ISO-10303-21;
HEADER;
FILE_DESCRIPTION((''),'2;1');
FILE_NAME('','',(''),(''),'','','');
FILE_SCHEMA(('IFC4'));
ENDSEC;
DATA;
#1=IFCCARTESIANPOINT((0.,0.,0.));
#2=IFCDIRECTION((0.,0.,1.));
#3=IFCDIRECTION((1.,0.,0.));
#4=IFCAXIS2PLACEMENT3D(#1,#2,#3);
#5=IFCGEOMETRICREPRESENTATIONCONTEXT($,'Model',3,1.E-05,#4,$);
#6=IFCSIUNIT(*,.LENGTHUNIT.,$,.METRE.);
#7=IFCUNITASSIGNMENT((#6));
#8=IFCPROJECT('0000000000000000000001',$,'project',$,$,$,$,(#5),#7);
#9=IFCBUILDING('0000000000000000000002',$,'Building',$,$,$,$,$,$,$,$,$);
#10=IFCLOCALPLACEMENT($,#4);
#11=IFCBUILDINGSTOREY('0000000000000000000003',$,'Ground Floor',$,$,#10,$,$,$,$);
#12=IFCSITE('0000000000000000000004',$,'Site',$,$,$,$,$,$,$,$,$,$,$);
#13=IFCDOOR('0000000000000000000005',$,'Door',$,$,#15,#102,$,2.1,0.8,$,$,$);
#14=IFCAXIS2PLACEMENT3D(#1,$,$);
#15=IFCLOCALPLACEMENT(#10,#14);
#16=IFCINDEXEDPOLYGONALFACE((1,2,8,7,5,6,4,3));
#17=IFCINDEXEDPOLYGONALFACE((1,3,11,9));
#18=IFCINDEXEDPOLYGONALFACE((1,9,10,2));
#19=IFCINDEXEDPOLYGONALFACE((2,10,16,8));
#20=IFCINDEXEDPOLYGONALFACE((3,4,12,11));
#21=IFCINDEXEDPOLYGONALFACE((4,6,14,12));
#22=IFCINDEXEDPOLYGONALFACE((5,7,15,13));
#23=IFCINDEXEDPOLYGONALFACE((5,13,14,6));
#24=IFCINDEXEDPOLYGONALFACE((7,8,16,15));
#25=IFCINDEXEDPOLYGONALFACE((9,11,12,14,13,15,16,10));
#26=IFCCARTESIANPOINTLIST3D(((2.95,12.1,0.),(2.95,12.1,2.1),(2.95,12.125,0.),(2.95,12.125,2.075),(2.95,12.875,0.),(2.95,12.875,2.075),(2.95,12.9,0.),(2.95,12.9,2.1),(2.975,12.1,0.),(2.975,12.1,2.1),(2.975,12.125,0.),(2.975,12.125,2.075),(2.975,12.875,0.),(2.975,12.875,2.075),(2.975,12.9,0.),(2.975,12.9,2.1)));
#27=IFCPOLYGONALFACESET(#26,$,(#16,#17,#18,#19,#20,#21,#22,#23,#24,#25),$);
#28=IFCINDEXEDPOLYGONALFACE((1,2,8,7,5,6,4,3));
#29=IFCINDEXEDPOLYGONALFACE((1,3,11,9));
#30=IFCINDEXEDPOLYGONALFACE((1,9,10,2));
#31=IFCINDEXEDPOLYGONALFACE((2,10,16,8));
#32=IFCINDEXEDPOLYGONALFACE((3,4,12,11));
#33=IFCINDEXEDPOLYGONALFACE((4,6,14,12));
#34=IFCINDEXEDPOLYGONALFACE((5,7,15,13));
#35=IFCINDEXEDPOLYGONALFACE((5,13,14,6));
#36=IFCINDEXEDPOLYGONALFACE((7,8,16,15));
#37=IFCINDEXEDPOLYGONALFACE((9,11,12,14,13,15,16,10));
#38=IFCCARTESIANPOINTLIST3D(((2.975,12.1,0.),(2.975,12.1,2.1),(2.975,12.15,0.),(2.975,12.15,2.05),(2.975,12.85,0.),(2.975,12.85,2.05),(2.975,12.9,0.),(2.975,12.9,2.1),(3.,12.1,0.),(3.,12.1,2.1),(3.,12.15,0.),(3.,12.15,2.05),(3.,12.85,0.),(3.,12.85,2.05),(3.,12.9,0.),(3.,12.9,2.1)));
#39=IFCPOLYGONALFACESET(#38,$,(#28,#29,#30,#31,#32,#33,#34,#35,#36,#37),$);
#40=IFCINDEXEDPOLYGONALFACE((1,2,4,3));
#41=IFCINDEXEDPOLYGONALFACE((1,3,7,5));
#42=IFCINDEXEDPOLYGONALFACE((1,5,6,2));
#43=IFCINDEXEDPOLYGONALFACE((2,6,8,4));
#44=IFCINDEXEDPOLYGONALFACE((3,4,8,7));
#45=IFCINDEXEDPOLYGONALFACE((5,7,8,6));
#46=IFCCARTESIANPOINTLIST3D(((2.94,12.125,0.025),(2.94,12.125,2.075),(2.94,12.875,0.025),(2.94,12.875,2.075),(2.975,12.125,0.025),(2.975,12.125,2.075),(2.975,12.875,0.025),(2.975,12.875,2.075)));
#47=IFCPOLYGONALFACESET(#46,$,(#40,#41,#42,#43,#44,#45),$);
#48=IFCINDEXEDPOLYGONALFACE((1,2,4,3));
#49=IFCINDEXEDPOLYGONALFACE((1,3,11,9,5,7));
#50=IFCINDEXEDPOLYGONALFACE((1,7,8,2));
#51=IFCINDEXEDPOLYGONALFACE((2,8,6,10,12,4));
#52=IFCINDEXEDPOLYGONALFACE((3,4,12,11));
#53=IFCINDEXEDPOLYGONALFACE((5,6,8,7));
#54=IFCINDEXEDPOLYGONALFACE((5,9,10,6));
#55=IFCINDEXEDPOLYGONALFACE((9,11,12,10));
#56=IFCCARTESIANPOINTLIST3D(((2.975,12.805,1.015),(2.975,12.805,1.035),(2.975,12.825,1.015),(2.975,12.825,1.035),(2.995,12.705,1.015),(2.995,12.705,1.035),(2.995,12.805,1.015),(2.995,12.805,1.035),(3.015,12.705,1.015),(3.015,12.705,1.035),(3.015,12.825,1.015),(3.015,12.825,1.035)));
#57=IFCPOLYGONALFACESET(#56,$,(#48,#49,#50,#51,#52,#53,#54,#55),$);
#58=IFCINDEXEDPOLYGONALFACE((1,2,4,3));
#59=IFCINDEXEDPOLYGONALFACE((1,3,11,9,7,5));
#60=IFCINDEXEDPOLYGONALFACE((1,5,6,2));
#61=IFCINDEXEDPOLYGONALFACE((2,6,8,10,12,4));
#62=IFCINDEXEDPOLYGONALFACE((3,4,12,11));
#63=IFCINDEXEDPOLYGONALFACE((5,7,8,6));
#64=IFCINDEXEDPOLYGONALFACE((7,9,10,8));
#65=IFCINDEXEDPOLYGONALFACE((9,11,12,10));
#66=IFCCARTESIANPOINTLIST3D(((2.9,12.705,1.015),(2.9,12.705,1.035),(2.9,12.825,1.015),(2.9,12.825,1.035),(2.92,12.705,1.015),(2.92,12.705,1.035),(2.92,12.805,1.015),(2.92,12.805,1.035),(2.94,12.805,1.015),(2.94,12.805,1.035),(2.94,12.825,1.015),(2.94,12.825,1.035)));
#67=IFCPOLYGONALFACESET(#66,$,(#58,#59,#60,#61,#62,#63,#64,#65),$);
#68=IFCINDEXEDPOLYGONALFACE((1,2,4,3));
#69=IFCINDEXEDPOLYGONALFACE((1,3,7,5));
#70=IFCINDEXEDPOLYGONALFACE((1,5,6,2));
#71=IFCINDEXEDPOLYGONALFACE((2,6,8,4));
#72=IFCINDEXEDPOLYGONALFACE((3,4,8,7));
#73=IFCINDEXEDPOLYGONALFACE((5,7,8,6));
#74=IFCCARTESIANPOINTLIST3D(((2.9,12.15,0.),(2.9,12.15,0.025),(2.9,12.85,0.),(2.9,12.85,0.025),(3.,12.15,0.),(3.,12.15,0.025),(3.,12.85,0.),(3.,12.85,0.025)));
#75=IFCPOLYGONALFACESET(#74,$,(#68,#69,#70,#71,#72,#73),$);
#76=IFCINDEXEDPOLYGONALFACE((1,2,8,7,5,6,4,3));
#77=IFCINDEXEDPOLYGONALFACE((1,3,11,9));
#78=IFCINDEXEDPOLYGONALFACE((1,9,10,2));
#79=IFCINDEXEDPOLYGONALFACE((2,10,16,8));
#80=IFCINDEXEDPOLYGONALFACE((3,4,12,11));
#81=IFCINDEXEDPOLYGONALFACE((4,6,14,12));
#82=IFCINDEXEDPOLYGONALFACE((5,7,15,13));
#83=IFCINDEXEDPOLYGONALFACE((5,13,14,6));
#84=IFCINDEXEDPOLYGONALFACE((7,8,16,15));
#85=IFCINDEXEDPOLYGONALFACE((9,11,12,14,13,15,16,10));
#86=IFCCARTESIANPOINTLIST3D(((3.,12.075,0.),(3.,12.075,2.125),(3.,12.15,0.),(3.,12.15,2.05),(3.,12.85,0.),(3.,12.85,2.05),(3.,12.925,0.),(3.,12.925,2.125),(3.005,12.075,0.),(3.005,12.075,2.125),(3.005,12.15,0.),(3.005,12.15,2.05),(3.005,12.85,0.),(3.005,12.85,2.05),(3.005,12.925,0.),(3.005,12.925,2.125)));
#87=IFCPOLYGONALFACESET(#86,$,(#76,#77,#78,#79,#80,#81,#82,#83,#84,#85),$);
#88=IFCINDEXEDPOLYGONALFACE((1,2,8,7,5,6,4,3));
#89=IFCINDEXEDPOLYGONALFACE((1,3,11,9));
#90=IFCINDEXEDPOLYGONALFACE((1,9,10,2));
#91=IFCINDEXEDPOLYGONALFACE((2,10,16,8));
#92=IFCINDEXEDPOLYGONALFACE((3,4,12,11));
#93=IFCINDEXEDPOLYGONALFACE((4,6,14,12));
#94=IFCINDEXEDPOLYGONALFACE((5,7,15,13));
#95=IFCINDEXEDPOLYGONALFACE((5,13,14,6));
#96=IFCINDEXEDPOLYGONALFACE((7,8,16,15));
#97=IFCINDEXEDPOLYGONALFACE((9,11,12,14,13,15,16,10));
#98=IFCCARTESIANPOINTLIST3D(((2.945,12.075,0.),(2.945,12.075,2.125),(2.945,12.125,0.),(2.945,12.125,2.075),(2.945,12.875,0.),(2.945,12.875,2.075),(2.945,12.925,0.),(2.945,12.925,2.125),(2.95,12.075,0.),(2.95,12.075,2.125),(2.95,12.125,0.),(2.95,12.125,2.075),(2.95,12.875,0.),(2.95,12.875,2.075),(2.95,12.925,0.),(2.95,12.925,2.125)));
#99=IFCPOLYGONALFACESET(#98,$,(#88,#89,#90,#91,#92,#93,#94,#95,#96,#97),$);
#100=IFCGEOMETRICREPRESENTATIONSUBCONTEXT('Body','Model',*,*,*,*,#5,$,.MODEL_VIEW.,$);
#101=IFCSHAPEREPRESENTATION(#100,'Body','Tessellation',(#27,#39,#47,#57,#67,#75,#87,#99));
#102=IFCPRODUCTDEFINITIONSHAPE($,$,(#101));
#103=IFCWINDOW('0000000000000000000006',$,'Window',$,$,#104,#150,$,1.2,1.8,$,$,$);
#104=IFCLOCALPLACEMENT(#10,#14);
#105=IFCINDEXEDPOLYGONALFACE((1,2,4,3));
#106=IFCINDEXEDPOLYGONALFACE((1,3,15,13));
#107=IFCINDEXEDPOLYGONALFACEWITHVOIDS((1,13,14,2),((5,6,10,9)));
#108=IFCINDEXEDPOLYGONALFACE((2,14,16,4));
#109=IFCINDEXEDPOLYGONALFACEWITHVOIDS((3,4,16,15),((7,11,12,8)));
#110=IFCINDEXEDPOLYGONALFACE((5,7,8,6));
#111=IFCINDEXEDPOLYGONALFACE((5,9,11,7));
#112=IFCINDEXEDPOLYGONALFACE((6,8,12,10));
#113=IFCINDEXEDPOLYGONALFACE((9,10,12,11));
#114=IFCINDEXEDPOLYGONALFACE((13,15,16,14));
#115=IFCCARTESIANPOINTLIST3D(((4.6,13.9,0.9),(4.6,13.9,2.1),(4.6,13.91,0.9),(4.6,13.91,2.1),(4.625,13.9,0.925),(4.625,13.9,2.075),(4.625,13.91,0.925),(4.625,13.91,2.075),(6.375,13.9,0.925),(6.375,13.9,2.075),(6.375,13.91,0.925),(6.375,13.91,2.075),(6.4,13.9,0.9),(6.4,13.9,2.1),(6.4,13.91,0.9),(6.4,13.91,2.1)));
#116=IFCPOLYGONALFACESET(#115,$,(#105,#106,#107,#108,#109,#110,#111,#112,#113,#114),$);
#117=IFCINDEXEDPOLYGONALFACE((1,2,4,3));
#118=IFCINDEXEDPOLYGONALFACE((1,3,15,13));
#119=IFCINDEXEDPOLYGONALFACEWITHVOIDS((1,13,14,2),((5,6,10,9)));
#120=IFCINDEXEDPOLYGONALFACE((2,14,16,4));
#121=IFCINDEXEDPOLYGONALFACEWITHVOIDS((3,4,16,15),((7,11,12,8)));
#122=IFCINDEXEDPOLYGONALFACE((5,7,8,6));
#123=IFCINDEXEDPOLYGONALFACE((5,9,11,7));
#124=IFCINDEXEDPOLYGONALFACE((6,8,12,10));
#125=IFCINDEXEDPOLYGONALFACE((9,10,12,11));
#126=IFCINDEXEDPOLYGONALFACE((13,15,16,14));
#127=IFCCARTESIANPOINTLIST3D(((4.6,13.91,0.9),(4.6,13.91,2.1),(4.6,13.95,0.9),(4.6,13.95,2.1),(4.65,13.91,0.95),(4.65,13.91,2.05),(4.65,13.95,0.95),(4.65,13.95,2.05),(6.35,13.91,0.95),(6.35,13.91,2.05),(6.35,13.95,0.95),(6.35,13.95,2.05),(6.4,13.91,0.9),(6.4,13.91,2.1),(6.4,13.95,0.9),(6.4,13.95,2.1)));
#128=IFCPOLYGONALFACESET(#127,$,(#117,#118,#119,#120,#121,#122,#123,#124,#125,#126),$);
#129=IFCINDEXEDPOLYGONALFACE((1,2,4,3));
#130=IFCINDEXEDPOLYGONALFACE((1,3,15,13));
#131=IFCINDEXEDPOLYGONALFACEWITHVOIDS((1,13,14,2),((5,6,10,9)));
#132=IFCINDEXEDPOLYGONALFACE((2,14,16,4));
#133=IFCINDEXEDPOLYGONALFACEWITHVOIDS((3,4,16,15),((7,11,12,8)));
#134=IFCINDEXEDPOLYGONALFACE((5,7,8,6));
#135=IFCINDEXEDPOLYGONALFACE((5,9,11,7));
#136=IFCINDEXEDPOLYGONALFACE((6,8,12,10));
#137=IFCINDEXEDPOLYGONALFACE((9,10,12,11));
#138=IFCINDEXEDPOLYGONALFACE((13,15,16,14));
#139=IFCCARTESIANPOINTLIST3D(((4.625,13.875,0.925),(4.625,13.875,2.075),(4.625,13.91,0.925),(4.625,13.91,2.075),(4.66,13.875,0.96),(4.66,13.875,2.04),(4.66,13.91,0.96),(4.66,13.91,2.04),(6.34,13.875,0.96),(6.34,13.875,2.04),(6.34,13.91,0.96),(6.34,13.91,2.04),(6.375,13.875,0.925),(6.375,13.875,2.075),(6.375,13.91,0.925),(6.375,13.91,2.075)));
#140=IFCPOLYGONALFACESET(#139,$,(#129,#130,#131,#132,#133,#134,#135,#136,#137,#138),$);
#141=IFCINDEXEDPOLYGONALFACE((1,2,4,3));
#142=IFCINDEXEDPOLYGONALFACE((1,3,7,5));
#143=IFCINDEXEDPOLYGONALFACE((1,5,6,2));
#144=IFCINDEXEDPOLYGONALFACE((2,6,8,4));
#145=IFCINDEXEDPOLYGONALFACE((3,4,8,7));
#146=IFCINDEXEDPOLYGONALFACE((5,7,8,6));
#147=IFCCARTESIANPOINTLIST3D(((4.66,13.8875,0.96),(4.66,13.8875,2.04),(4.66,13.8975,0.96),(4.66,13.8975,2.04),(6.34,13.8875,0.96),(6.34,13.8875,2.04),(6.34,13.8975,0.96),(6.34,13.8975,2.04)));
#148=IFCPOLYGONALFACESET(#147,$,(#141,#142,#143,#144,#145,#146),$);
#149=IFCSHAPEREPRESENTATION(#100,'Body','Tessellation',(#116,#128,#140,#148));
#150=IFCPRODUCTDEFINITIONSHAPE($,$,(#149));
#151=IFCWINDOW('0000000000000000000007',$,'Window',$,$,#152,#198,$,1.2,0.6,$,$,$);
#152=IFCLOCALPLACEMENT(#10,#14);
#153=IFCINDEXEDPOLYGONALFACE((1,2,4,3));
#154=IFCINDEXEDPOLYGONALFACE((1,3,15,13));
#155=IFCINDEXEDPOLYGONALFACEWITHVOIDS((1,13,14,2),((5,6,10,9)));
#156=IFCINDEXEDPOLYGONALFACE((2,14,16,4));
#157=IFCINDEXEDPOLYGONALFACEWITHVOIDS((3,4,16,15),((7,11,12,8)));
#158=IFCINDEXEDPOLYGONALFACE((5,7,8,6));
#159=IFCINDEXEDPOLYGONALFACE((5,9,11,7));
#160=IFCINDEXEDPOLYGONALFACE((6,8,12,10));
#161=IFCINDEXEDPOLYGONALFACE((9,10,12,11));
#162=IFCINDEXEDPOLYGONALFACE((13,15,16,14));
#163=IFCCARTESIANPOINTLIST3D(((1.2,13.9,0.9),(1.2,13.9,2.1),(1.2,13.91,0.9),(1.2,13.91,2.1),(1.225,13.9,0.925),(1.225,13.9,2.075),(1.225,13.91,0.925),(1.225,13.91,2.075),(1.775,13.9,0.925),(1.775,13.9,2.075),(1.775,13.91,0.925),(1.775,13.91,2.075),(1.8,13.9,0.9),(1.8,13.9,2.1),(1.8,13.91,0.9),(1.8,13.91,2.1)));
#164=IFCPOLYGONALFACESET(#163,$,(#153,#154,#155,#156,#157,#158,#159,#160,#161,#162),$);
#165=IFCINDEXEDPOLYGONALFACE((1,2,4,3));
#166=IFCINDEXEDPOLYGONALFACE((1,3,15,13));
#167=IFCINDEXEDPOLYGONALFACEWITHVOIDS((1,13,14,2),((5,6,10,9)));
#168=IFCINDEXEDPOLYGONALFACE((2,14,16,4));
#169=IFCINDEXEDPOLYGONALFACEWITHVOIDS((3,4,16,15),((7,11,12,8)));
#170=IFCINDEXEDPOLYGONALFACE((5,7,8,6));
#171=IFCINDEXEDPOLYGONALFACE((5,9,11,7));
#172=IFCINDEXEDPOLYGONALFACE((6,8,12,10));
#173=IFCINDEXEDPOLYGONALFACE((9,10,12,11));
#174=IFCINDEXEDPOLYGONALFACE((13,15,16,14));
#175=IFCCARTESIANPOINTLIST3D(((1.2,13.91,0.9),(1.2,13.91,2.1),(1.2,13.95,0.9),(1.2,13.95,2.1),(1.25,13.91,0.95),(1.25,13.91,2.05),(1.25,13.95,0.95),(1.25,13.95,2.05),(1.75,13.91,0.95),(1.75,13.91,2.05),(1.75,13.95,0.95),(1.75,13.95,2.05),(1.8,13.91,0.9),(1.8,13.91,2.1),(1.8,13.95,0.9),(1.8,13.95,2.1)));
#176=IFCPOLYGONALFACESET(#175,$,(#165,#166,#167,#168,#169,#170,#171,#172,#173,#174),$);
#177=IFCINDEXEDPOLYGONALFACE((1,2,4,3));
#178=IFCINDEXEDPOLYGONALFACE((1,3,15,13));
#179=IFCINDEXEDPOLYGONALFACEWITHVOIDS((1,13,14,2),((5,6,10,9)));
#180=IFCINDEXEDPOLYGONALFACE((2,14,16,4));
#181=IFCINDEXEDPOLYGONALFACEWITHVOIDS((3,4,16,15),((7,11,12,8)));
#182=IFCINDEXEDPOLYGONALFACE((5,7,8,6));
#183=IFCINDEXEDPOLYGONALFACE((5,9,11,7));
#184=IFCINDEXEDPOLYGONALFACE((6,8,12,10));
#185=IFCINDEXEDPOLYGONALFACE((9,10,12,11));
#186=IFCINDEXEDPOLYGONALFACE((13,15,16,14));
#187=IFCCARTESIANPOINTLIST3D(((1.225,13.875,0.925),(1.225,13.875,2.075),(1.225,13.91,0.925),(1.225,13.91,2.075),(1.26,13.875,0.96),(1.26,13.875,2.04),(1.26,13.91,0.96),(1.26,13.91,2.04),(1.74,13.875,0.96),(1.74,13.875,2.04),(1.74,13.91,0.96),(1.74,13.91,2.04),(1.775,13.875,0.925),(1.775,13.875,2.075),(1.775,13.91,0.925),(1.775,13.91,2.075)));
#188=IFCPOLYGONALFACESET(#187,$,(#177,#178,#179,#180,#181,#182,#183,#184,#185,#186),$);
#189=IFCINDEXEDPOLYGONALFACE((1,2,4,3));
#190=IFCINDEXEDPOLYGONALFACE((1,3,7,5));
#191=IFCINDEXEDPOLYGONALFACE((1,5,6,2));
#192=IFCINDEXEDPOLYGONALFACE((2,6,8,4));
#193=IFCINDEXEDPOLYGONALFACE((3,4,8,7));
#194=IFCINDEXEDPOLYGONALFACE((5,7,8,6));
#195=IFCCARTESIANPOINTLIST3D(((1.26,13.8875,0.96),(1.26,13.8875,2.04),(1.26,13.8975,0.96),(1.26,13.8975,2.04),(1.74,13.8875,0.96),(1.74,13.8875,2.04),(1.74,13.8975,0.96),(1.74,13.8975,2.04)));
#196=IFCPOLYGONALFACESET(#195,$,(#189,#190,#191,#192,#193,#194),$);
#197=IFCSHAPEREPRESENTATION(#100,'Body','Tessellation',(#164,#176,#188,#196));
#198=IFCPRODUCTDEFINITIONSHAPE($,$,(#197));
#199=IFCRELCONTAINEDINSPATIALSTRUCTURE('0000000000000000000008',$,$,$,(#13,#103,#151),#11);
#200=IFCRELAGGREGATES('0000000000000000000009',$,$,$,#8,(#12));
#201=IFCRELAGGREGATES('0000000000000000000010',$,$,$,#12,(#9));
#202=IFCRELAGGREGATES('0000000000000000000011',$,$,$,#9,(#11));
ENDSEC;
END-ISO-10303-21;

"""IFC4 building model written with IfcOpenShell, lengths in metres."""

from ifc_helpers import new_model, si_unit, frame, origin_with_axes, place, context, subcontext, project, spatial, line, indexed_curve, outline, extrude, element, save


model = new_model("IFC4")

# Units and contexts
model_context = context("Model", 3, precision=1e-05, world=origin_with_axes())
body_context = subcontext(model_context, "Body", "Model", "MODEL_VIEW")
ifc_project = project(units=[si_unit("LENGTHUNIT", "METRE")], contexts=[model_context])

# Site, building, storey
site = spatial("IfcSite", under=ifc_project, Name="Site")
building = spatial("IfcBuilding", under=site, Name="Building")
storey_placement = place(None, origin_with_axes())
storey = spatial("IfcBuildingStorey", under=building, at=storey_placement, Name="Ground Floor")

# Door
door_1_placement = place(storey_placement, frame((3.0, 12.1, 0.0), z_axis=(0.0, 0.0, 1.0), x_axis=(0.0, 1.0, 0.0)))
element("IfcDoor", 1, at=door_1_placement, inside=storey, Name="Door", OverallHeight=2.1, OverallWidth=0.8, context=body_context, shape_type="SweptSolid", body=[
    extrude(outline(indexed_curve([(0.0, 0.0), (0.0, 2.1), (0.8, 2.1), (0.8, 0.0), (0.775, 0.0), (0.775, 2.075), (0.025, 2.075), (0.025, 0.0)], segments=[line(1, 2, 3, 4, 5, 6, 7, 8, 1)])), frame((0.0, 0.025, 0.0), z_axis=(0.0, -1.0, 0.0), x_axis=(1.0, 0.0, 0.0)), (0.0, 0.0, -1.0), 0.025),
    extrude(outline(indexed_curve([(0.0, 0.0), (0.0, 2.1), (0.8, 2.1), (0.8, 0.0), (0.75, 0.0), (0.75, 2.05), (0.05, 2.05), (0.05, 0.0)], segments=[line(1, 2, 3, 4, 5, 6, 7, 8, 1)])), frame((0.0, 0.0, 0.0), z_axis=(0.0, -1.0, 0.0), x_axis=(1.0, 0.0, 0.0)), (0.0, 0.0, -1.0), 0.025),
    extrude(outline(indexed_curve([(0.0, 0.0), (0.75, 0.0), (0.75, 0.035), (0.0, 0.035)], segments=[line(1, 2, 3, 4, 1)])), frame((0.025, 0.025, 0.025), z_axis=(0.0, 0.0, 1.0), x_axis=(1.0, 0.0, 0.0)), (0.0, 0.0, 1.0), 2.05),
    extrude(outline(indexed_curve([(0.0, 0.0), (0.0, -0.04), (-0.12, -0.04), (-0.12, -0.02), (-0.02, -0.02), (-0.02, 0.0)], segments=[line(1, 2, 3, 4, 5, 6, 1)])), frame((0.725, 0.025, 1.015), z_axis=(0.0, 0.0, 1.0), x_axis=(1.0, 0.0, 0.0)), (0.0, 0.0, 1.0), 0.02),
    extrude(outline(indexed_curve([(0.0, 0.0), (0.0, 0.04), (-0.12, 0.04), (-0.12, 0.02), (-0.02, 0.02), (-0.02, 0.0)], segments=[line(1, 2, 3, 4, 5, 6, 1)])), frame((0.725, 0.06, 1.015), z_axis=(0.0, 0.0, 1.0), x_axis=(1.0, 0.0, 0.0)), (0.0, 0.0, 1.0), 0.02),
    extrude(outline(indexed_curve([(0.0, 0.0), (0.7, 0.0), (0.7, 0.1), (0.0, 0.1)], segments=[line(1, 2, 3, 4, 1)])), frame((0.05, 0.0, 0.0), z_axis=(0.0, 0.0, 1.0), x_axis=(1.0, 0.0, 0.0)), (0.0, 0.0, 1.0), 0.025),
    extrude(outline(indexed_curve([(0.0, 0.0), (0.0, 2.125), (0.85, 2.125), (0.85, 0.0), (0.775, 0.0), (0.775, 2.05), (0.075, 2.05), (0.075, 0.0)], segments=[line(1, 2, 3, 4, 5, 6, 7, 8, 1)])), frame((-0.025, -0.005, 0.0), z_axis=(0.0, -1.0, 0.0), x_axis=(1.0, 0.0, 0.0)), (0.0, 0.0, -1.0), 0.005),
    extrude(outline(indexed_curve([(0.0, 0.0), (0.0, 2.125), (0.85, 2.125), (0.85, 0.0), (0.8, 0.0), (0.8, 2.075), (0.05, 2.075), (0.05, 0.0)], segments=[line(1, 2, 3, 4, 5, 6, 7, 8, 1)])), frame((-0.025, 0.05, 0.0), z_axis=(0.0, -1.0, 0.0), x_axis=(1.0, 0.0, 0.0)), (0.0, 0.0, -1.0), 0.005),
])

# Windows
window_1_placement = place(storey_placement, frame((6.4, 14.0, 0.9), z_axis=(0.0, 0.0, 1.0), x_axis=(-1.0, 0.0, 0.0)))
element("IfcWindow", 2, at=window_1_placement, inside=storey, Name="Window", OverallHeight=1.2, OverallWidth=1.8, context=body_context, shape_type="SweptSolid", body=[
    extrude(outline(indexed_curve([(0.0, 0.0), (1.8, 0.0), (1.8, 1.2), (0.0, 1.2)], segments=[line(1, 2, 3, 4, 1)]), holes=[indexed_curve([(0.025, 0.025), (1.775, 0.025), (1.775, 1.175), (0.025, 1.175)], segments=[line(1, 2, 3, 4, 1)])]), frame((0.0, 0.09, 0.0), z_axis=(0.0, -1.0, 0.0), x_axis=(1.0, 0.0, 0.0)), (0.0, 0.0, -1.0), 0.01),
    extrude(outline(indexed_curve([(0.0, 0.0), (1.8, 0.0), (1.8, 1.2), (0.0, 1.2)], segments=[line(1, 2, 3, 4, 1)]), holes=[indexed_curve([(0.05, 0.05), (1.75, 0.05), (1.75, 1.15), (0.05, 1.15)], segments=[line(1, 2, 3, 4, 1)])]), frame((0.0, 0.05, 0.0), z_axis=(0.0, -1.0, 0.0), x_axis=(1.0, 0.0, 0.0)), (0.0, 0.0, -1.0), 0.04),
    extrude(outline(indexed_curve([(0.0, 0.0), (1.75, 0.0), (1.75, 1.15), (0.0, 1.15)], segments=[line(1, 2, 3, 4, 1)]), holes=[indexed_curve([(0.035, 0.035), (1.715, 0.035), (1.715, 1.115), (0.035, 1.115)], segments=[line(1, 2, 3, 4, 1)])]), frame((0.025, 0.09, 0.025), z_axis=(0.0, -1.0, 0.0), x_axis=(1.0, 0.0, 0.0)), (0.0, 0.0, -1.0), 0.035),
    extrude(outline(indexed_curve([(0.035, 0.035), (1.715, 0.035), (1.715, 1.115), (0.035, 1.115)], segments=[line(1, 2, 3, 4, 1)])), frame((0.025, 0.1025, 0.025), z_axis=(0.0, -1.0, 0.0), x_axis=(1.0, 0.0, 0.0)), (0.0, 0.0, -1.0), 0.01),
])
window_2_placement = place(storey_placement, frame((1.8, 14.0, 0.9), z_axis=(0.0, 0.0, 1.0), x_axis=(-1.0, 0.0, 0.0)))
element("IfcWindow", 3, at=window_2_placement, inside=storey, Name="Window", OverallHeight=1.2, OverallWidth=0.6, context=body_context, shape_type="SweptSolid", body=[
    extrude(outline(indexed_curve([(0.0, 0.0), (0.6, 0.0), (0.6, 1.2), (0.0, 1.2)], segments=[line(1, 2, 3, 4, 1)]), holes=[indexed_curve([(0.025, 0.025), (0.575, 0.025), (0.575, 1.175), (0.025, 1.175)], segments=[line(1, 2, 3, 4, 1)])]), frame((0.0, 0.09, 0.0), z_axis=(0.0, -1.0, 0.0), x_axis=(1.0, 0.0, 0.0)), (0.0, 0.0, -1.0), 0.01),
    extrude(outline(indexed_curve([(0.0, 0.0), (0.6, 0.0), (0.6, 1.2), (0.0, 1.2)], segments=[line(1, 2, 3, 4, 1)]), holes=[indexed_curve([(0.05, 0.05), (0.55, 0.05), (0.55, 1.15), (0.05, 1.15)], segments=[line(1, 2, 3, 4, 1)])]), frame((0.0, 0.05, 0.0), z_axis=(0.0, -1.0, 0.0), x_axis=(1.0, 0.0, 0.0)), (0.0, 0.0, -1.0), 0.04),
    extrude(outline(indexed_curve([(0.0, 0.0), (0.55, 0.0), (0.55, 1.15), (0.0, 1.15)], segments=[line(1, 2, 3, 4, 1)]), holes=[indexed_curve([(0.035, 0.035), (0.515, 0.035), (0.515, 1.115), (0.035, 1.115)], segments=[line(1, 2, 3, 4, 1)])]), frame((0.025, 0.09, 0.025), z_axis=(0.0, -1.0, 0.0), x_axis=(1.0, 0.0, 0.0)), (0.0, 0.0, -1.0), 0.035),
    extrude(outline(indexed_curve([(0.035, 0.035), (0.515, 0.035), (0.515, 1.115), (0.035, 1.115)], segments=[line(1, 2, 3, 4, 1)])), frame((0.025, 0.1025, 0.025), z_axis=(0.0, -1.0, 0.0), x_axis=(1.0, 0.0, 0.0)), (0.0, 0.0, -1.0), 0.01),
])

save(model, "model.ifc")
